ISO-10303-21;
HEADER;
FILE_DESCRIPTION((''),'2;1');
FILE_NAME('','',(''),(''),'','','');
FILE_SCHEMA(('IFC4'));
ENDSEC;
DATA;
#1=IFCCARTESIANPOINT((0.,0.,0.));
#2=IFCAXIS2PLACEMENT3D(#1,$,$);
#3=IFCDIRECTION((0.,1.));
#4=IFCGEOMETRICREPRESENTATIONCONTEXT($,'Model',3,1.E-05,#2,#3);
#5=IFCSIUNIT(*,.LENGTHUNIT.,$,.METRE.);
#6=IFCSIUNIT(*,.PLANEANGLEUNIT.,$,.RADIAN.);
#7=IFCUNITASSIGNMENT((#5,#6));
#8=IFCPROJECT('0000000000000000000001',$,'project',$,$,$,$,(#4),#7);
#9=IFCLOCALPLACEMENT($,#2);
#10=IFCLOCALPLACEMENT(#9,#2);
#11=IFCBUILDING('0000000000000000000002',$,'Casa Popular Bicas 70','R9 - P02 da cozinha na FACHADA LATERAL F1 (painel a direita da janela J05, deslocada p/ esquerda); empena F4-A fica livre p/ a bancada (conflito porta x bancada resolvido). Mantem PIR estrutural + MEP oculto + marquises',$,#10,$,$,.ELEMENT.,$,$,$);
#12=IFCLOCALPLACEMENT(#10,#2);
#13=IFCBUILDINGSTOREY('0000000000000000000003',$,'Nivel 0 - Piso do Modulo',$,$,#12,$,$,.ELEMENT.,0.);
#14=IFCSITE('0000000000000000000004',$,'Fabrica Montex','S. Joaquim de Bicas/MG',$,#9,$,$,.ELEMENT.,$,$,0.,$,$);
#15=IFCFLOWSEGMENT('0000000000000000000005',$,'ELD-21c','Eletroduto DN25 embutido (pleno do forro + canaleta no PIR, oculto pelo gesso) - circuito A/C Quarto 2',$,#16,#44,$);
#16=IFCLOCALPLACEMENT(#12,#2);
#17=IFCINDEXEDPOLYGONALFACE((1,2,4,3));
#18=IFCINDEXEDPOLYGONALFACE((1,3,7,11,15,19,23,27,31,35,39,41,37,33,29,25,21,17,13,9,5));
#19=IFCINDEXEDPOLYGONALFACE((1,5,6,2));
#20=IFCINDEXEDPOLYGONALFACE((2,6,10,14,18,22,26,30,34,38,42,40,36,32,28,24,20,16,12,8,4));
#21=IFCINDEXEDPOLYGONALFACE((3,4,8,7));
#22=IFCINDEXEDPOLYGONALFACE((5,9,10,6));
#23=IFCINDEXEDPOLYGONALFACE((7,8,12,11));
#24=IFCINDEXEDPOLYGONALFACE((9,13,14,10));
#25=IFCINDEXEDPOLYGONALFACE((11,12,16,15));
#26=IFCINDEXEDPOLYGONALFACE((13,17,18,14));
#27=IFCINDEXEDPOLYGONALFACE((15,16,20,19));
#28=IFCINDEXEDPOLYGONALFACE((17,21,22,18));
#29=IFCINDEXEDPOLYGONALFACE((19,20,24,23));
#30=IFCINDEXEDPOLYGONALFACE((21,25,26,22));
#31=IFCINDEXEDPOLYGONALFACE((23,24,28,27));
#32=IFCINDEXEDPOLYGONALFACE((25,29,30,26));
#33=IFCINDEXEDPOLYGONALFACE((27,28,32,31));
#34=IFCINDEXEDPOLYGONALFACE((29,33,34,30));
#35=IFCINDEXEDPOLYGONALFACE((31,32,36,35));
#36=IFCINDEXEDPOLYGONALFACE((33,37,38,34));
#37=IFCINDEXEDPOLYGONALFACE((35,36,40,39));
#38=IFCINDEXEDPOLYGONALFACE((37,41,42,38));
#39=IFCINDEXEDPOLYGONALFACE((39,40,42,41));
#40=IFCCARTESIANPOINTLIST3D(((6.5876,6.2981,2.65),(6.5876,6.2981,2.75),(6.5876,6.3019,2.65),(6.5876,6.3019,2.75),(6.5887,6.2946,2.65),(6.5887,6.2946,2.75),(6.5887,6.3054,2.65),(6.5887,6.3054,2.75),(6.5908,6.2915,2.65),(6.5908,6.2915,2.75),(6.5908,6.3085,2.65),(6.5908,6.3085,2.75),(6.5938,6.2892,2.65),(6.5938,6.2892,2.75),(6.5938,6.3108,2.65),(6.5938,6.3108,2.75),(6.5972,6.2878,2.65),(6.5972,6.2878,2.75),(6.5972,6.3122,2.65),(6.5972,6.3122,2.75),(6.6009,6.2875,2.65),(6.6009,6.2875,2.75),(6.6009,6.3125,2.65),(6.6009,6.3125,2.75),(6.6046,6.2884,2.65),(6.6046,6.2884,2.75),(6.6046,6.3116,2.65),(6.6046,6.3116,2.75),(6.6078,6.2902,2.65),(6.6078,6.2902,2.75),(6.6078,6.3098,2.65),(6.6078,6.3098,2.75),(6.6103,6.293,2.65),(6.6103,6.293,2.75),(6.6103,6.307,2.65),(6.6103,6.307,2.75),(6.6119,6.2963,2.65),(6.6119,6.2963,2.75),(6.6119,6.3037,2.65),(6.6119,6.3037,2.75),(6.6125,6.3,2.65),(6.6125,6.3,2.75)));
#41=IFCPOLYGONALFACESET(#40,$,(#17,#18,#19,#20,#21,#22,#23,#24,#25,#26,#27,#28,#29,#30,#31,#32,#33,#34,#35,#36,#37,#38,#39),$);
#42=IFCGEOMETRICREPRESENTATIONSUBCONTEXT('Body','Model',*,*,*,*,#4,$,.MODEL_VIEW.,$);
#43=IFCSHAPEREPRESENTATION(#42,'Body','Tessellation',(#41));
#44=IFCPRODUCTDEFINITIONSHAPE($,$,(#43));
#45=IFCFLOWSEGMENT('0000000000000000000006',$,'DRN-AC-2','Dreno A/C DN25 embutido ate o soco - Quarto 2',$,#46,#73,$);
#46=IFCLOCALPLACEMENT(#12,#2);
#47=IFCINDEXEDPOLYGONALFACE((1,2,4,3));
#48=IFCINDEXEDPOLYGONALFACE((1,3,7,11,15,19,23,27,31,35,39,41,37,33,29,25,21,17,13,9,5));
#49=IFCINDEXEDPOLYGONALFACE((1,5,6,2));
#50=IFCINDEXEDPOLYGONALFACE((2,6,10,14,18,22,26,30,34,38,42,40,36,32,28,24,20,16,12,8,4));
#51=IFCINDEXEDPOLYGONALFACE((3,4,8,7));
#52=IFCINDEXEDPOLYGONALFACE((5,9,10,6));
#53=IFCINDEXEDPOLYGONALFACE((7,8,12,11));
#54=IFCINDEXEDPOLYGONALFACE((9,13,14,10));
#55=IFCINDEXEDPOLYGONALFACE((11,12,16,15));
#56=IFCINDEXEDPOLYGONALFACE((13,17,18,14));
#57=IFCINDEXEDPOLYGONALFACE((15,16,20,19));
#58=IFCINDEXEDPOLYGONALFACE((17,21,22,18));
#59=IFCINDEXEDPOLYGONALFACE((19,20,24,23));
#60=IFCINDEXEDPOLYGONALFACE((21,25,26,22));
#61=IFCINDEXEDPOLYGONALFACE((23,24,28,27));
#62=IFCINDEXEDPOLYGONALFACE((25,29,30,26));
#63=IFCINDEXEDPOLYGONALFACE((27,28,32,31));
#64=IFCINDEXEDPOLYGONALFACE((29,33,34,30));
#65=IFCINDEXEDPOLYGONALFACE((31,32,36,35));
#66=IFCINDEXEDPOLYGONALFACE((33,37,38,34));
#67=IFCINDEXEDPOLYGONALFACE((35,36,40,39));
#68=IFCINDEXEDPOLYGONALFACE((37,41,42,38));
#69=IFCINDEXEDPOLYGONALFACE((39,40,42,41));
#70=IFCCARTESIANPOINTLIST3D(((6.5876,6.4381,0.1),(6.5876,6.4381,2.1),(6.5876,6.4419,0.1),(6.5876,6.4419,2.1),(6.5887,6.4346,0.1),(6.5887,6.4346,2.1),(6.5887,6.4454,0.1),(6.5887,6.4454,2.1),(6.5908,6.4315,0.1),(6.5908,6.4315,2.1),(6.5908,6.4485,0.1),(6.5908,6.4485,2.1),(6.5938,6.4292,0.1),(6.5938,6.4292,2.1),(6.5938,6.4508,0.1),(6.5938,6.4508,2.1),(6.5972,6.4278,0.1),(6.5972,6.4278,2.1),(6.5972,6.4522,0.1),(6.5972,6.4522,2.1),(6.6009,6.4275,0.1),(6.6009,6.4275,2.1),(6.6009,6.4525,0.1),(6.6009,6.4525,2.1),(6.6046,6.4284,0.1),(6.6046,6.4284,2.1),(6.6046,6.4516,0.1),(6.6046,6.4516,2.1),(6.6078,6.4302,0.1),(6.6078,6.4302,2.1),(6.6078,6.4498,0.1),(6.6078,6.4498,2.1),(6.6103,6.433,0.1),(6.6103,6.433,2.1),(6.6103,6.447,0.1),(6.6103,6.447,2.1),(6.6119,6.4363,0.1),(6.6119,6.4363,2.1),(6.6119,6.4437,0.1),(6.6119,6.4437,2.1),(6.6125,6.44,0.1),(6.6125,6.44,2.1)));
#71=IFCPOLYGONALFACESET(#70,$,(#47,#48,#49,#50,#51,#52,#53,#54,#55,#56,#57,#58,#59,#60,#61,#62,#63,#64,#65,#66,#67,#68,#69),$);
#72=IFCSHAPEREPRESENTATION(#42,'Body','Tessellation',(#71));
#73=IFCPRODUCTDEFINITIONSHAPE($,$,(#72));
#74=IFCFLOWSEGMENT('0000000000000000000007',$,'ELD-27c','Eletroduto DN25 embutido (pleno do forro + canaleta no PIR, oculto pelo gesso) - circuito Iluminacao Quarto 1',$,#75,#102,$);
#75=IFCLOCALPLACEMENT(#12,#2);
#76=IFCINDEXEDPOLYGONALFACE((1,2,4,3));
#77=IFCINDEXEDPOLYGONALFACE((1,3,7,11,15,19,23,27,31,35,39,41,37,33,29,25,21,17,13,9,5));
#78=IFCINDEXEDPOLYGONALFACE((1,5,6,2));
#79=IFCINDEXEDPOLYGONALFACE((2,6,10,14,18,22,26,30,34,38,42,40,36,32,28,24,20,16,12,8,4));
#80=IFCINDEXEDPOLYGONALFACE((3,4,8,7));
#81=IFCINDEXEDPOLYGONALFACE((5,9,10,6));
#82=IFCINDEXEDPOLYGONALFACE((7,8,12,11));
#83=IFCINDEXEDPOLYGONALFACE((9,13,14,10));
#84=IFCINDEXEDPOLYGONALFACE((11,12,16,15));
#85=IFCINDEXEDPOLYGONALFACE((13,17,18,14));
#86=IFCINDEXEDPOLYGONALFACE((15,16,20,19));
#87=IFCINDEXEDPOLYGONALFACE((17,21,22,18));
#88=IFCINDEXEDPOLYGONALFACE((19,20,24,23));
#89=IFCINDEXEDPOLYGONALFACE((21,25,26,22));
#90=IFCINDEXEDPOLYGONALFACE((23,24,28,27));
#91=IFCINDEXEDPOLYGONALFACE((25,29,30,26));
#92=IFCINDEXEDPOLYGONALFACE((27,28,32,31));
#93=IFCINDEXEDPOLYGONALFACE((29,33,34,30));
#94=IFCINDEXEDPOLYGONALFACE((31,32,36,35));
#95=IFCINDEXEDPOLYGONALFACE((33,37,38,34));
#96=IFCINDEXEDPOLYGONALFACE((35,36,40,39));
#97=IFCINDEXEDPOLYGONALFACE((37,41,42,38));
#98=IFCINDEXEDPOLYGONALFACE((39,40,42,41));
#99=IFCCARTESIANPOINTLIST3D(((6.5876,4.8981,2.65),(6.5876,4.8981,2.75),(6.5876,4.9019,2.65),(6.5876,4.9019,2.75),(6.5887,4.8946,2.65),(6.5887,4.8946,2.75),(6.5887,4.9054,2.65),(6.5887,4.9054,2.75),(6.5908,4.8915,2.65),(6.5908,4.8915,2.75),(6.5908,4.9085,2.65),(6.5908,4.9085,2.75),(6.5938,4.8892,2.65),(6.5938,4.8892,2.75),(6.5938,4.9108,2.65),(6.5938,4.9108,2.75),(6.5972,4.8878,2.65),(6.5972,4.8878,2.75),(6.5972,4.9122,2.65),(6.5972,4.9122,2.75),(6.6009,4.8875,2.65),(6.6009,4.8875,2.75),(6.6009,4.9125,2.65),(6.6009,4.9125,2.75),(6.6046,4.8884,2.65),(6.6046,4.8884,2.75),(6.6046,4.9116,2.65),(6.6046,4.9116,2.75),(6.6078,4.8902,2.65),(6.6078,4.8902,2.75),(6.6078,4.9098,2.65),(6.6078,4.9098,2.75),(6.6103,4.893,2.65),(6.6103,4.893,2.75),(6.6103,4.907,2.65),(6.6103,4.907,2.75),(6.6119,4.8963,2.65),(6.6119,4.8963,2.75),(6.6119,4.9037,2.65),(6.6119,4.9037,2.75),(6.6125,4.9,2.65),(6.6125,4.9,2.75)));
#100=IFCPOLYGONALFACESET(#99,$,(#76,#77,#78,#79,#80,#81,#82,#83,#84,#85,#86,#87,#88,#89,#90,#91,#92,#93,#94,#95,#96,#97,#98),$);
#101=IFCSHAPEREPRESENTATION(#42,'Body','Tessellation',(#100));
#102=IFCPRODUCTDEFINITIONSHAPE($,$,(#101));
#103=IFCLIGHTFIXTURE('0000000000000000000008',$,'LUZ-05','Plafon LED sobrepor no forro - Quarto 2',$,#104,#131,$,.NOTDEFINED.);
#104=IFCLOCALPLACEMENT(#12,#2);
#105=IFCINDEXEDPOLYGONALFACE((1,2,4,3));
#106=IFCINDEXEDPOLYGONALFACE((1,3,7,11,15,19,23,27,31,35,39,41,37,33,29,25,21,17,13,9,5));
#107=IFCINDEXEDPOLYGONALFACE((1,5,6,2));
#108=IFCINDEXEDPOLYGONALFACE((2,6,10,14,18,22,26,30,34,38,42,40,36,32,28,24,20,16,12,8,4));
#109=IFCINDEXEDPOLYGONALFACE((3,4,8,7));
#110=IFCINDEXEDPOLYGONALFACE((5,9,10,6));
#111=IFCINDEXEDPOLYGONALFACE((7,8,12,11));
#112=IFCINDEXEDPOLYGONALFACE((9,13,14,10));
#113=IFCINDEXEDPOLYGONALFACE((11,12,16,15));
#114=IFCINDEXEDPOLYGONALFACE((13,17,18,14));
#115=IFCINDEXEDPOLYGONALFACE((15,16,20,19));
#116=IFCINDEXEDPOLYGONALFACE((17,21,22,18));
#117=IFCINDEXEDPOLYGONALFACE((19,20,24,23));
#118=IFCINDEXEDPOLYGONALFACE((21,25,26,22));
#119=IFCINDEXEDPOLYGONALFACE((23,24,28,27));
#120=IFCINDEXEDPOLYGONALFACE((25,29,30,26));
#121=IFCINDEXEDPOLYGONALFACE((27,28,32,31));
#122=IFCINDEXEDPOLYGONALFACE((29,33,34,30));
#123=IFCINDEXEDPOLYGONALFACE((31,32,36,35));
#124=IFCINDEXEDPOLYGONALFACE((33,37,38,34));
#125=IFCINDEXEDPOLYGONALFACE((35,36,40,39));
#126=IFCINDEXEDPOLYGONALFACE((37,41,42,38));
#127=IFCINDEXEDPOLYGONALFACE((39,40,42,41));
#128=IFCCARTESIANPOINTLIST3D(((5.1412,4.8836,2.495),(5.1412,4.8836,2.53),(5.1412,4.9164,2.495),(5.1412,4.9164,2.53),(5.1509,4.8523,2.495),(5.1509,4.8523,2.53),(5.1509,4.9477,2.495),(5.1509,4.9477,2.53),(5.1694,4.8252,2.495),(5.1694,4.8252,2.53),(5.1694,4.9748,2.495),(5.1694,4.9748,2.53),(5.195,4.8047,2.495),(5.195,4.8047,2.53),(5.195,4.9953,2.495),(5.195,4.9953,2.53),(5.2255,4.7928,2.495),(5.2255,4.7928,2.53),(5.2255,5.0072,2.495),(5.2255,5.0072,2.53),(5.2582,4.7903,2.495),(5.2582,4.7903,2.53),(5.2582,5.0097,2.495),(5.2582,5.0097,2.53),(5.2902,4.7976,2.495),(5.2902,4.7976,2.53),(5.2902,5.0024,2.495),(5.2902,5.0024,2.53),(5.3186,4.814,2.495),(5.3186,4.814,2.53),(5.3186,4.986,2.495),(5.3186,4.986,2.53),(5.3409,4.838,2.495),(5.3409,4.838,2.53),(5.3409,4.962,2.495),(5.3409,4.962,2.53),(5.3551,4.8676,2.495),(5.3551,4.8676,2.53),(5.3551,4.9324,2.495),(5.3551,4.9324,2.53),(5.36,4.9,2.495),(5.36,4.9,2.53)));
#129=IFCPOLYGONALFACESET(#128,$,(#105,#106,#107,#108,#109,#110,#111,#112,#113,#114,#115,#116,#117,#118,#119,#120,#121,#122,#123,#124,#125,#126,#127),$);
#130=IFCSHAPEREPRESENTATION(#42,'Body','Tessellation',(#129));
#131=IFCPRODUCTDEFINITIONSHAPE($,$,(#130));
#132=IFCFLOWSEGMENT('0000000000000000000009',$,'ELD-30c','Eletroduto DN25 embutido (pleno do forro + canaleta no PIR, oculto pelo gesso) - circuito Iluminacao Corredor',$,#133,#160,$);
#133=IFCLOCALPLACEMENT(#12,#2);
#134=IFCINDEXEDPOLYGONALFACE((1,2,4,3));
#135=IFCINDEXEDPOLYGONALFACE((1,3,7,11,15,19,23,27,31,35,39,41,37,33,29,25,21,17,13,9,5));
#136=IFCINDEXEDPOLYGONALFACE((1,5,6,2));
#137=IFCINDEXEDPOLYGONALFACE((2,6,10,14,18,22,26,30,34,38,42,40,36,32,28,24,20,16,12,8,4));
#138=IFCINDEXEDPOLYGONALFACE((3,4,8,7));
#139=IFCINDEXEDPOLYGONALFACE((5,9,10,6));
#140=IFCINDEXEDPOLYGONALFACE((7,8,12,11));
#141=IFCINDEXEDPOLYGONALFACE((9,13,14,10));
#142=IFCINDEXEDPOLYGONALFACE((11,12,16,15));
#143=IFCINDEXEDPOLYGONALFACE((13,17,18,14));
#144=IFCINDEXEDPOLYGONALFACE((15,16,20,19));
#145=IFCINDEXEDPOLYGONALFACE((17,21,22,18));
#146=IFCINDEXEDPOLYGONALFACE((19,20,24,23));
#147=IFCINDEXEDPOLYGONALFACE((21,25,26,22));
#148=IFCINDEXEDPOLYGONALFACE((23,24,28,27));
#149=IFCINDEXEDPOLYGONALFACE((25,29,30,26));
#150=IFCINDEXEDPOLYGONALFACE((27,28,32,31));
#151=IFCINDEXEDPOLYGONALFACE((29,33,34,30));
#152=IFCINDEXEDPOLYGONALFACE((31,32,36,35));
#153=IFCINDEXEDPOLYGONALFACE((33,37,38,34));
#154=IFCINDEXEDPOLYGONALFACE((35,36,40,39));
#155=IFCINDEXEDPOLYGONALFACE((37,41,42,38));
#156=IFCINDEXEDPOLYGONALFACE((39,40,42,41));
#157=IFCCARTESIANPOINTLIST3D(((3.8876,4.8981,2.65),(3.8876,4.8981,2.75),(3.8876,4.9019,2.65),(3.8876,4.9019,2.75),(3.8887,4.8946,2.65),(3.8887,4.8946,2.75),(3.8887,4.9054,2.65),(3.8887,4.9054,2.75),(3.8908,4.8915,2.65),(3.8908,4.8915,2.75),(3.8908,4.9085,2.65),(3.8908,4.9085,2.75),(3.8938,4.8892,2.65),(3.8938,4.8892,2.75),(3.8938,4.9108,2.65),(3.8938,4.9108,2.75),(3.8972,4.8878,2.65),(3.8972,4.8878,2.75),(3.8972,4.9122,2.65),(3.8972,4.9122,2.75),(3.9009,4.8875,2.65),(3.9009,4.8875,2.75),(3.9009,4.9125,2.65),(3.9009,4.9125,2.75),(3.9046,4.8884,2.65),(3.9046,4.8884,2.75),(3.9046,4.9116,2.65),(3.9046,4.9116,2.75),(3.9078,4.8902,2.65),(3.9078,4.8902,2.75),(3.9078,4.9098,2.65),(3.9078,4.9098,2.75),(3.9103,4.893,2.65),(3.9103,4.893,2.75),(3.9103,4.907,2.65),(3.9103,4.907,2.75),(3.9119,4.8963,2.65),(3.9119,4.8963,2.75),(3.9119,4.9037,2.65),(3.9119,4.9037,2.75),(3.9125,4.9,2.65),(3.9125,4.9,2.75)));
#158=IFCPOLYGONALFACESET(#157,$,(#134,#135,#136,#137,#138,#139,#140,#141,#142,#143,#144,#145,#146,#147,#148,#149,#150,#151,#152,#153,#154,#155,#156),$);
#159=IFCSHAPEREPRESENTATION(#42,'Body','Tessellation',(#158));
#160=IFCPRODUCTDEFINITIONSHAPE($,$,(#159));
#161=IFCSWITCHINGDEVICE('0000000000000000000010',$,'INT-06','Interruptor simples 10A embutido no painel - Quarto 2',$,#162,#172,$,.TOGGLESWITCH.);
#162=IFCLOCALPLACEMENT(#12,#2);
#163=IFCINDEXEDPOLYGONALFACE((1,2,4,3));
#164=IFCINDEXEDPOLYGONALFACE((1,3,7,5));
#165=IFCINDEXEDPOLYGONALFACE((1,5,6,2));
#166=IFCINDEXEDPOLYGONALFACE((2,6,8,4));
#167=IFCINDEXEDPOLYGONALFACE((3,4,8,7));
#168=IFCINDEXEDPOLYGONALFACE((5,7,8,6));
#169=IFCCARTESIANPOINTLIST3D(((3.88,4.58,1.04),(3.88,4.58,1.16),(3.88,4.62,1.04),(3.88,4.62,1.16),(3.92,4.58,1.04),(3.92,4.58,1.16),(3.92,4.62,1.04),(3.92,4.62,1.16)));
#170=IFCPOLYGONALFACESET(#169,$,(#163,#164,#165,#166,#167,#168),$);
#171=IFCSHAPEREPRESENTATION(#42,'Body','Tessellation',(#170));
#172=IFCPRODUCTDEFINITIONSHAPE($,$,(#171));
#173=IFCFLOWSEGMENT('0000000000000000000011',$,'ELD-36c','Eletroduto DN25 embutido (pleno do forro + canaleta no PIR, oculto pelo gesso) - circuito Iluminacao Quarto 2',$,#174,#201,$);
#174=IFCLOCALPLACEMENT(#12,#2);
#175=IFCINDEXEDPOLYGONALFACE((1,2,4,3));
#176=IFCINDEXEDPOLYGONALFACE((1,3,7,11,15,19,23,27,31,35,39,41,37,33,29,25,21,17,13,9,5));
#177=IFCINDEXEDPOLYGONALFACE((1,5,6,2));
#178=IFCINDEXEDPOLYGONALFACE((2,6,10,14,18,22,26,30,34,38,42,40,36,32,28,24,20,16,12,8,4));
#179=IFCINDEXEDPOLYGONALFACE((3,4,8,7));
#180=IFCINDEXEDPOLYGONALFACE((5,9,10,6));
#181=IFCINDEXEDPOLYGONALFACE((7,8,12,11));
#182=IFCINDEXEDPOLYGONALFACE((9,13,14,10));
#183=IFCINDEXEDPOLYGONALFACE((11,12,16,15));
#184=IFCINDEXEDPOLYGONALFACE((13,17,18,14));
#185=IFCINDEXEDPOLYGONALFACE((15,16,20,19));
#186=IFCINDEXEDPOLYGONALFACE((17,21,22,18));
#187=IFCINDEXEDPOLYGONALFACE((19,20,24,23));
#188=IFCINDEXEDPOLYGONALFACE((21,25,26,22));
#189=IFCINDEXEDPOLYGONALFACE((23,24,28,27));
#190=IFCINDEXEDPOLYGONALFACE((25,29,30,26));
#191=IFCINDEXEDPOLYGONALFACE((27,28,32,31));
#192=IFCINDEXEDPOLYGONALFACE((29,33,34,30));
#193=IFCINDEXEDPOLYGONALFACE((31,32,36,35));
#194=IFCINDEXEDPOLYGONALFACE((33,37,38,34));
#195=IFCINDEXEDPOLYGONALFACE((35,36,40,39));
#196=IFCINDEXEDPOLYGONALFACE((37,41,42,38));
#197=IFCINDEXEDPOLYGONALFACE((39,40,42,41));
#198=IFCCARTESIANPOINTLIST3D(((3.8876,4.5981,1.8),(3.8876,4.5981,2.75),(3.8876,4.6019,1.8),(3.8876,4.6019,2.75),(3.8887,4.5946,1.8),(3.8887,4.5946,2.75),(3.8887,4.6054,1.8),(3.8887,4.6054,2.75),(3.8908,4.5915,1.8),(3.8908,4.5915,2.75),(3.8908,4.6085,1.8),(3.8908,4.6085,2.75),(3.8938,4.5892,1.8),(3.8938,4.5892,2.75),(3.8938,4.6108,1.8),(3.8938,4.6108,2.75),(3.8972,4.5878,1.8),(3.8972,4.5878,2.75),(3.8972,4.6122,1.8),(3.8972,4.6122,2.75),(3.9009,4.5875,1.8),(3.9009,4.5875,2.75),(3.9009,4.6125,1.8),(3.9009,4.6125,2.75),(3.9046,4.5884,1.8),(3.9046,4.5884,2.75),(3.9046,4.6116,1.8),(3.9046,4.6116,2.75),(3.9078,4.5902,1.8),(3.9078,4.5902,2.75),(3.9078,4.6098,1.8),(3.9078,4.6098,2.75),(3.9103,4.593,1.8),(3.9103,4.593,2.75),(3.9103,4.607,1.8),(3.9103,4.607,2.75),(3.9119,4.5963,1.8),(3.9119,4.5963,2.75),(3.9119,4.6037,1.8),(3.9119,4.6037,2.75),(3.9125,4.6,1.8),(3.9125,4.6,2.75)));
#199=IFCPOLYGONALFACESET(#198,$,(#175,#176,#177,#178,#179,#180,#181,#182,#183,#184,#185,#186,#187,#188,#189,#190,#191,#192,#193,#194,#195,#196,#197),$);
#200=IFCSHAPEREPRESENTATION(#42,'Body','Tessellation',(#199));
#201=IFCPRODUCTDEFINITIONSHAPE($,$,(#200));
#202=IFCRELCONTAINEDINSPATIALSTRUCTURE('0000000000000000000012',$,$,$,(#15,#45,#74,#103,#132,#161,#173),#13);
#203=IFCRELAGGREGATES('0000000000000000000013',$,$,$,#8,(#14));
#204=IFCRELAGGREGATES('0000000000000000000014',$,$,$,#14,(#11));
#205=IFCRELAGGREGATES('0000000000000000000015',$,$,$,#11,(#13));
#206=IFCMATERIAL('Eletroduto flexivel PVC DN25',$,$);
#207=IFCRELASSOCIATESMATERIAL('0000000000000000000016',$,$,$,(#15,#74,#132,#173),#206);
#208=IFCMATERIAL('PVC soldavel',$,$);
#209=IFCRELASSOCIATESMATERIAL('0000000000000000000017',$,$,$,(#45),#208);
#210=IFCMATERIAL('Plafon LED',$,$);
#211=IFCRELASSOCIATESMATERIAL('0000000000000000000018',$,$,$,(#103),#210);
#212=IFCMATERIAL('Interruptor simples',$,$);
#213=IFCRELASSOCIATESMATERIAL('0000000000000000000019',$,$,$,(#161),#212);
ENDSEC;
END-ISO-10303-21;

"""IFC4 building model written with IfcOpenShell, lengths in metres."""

from ifc_helpers import new_model, si_unit, direction, frame, frame_2d, origin, origin_2d, place, context, subcontext, project, spatial, rectangle, circle, extrude, material, element, save


model = new_model("IFC4")

# Units and contexts
model_context_1 = context("Model", 3, precision=1e-05, world=origin(), true_north=direction((0.0, 1.0)))
body_context_1 = subcontext(model_context_1, "Body", "Model", "MODEL_VIEW")
ifc_project = project(units=[si_unit("LENGTHUNIT", "METRE"), si_unit("PLANEANGLEUNIT", "RADIAN")], contexts=[model_context_1])

# Site, building, storey
site_placement = place(None, origin())
site = spatial("IfcSite", under=ifc_project, at=site_placement, Name="Fabrica Montex", Description="S. Joaquim de Bicas/MG", CompositionType="ELEMENT", RefElevation=0.0)
building_placement = place(site_placement, origin())
building = spatial("IfcBuilding", under=site, at=building_placement, Name="Casa Popular Bicas 70", Description="R9 - P02 da cozinha na FACHADA LATERAL F1 (painel a direita da janela J05, deslocada p/ esquerda); empena F4-A fica livre p/ a bancada (conflito porta x bancada resolvido). Mantem PIR estrutural + MEP oculto + marquises", CompositionType="ELEMENT")
storey_placement = place(building_placement, origin())
storey = spatial("IfcBuildingStorey", under=building, at=storey_placement, Name="Nivel 0 - Piso do Modulo", CompositionType="ELEMENT", Elevation=0.0)

# Shared definitions
ifc_material_1 = material(Name="Eletroduto flexivel PVC DN25")

# Flow segments
flow_segment_1_placement = place(storey_placement, frame((6.6, 6.3, 2.75), z_axis=(0.0, 0.0, -1.0), x_axis=(1.0, 0.0, 0.0)))
element("IfcFlowSegment", 1, at=flow_segment_1_placement, inside=storey, material=ifc_material_1, Name="ELD-21c", Description="Eletroduto DN25 embutido (pleno do forro + canaleta no PIR, oculto pelo gesso) - circuito A/C Quarto 2", context=body_context_1, shape_type="SweptSolid", body=[
    extrude(circle(Radius=0.0125, at=origin_2d()), origin(), (0.0, 0.0, 1.0), 0.1),
])
ifc_material_2 = material(Name="PVC soldavel")
flow_segment_2_placement = place(storey_placement, frame((6.6, 6.44, 2.1), z_axis=(0.0, 0.0, -1.0), x_axis=(1.0, 0.0, 0.0)))
element("IfcFlowSegment", 2, at=flow_segment_2_placement, inside=storey, material=ifc_material_2, Name="DRN-AC-2", Description="Dreno A/C DN25 embutido ate o soco - Quarto 2", context=body_context_1, shape_type="SweptSolid", body=[
    extrude(circle(Radius=0.0125, at=origin_2d()), origin(), (0.0, 0.0, 1.0), 2.0),
])
flow_segment_3_placement = place(storey_placement, frame((6.6, 4.9, 2.75), z_axis=(0.0, 0.0, -1.0), x_axis=(1.0, 0.0, 0.0)))
element("IfcFlowSegment", 3, at=flow_segment_3_placement, inside=storey, material=ifc_material_1, Name="ELD-27c", Description="Eletroduto DN25 embutido (pleno do forro + canaleta no PIR, oculto pelo gesso) - circuito Iluminacao Quarto 1", context=body_context_1, shape_type="SweptSolid", body=[
    extrude(circle(Radius=0.0125, at=origin_2d()), origin(), (0.0, 0.0, 1.0), 0.1),
])

# Light fixture
ifc_material_3 = material(Name="Plafon LED")
light_fixture_placement = place(storey_placement, frame((5.25, 4.9, 2.495)))
element("IfcLightFixture", 4, at=light_fixture_placement, inside=storey, material=ifc_material_3, Name="LUZ-05", Description="Plafon LED sobrepor no forro - Quarto 2", PredefinedType="NOTDEFINED", context=body_context_1, shape_type="SweptSolid", body=[
    extrude(circle(Radius=0.11, at=origin_2d()), origin(), (0.0, 0.0, 1.0), 0.035),
])

# Flow segment
flow_segment_4_placement = place(storey_placement, frame((3.9, 4.9, 2.75), z_axis=(0.0, 0.0, -1.0), x_axis=(1.0, 0.0, 0.0)))
element("IfcFlowSegment", 5, at=flow_segment_4_placement, inside=storey, material=ifc_material_1, Name="ELD-30c", Description="Eletroduto DN25 embutido (pleno do forro + canaleta no PIR, oculto pelo gesso) - circuito Iluminacao Corredor", context=body_context_1, shape_type="SweptSolid", body=[
    extrude(circle(Radius=0.0125, at=origin_2d()), origin(), (0.0, 0.0, 1.0), 0.1),
])

# Switching device
ifc_material_4 = material(Name="Interruptor simples")
switching_device_placement = place(storey_placement, frame((3.88, 4.58, 1.04)))
element("IfcSwitchingDevice", 6, at=switching_device_placement, inside=storey, material=ifc_material_4, Name="INT-06", Description="Interruptor simples 10A embutido no painel - Quarto 2", PredefinedType="TOGGLESWITCH", context=body_context_1, shape_type="SweptSolid", body=[
    extrude(rectangle(XDim=0.04, YDim=0.04, at=frame_2d((0.02, 0.02))), origin(), (0.0, 0.0, 1.0), 0.12),
])

# Flow segment
flow_segment_5_placement = place(storey_placement, frame((3.9, 4.6, 2.75), z_axis=(0.0, 0.0, -1.0), x_axis=(1.0, 0.0, 0.0)))
element("IfcFlowSegment", 7, at=flow_segment_5_placement, inside=storey, material=ifc_material_1, Name="ELD-36c", Description="Eletroduto DN25 embutido (pleno do forro + canaleta no PIR, oculto pelo gesso) - circuito Iluminacao Quarto 2", context=body_context_1, shape_type="SweptSolid", body=[
    extrude(circle(Radius=0.0125, at=origin_2d()), origin(), (0.0, 0.0, 1.0), 0.95),
])

save(model, "model.ifc")
